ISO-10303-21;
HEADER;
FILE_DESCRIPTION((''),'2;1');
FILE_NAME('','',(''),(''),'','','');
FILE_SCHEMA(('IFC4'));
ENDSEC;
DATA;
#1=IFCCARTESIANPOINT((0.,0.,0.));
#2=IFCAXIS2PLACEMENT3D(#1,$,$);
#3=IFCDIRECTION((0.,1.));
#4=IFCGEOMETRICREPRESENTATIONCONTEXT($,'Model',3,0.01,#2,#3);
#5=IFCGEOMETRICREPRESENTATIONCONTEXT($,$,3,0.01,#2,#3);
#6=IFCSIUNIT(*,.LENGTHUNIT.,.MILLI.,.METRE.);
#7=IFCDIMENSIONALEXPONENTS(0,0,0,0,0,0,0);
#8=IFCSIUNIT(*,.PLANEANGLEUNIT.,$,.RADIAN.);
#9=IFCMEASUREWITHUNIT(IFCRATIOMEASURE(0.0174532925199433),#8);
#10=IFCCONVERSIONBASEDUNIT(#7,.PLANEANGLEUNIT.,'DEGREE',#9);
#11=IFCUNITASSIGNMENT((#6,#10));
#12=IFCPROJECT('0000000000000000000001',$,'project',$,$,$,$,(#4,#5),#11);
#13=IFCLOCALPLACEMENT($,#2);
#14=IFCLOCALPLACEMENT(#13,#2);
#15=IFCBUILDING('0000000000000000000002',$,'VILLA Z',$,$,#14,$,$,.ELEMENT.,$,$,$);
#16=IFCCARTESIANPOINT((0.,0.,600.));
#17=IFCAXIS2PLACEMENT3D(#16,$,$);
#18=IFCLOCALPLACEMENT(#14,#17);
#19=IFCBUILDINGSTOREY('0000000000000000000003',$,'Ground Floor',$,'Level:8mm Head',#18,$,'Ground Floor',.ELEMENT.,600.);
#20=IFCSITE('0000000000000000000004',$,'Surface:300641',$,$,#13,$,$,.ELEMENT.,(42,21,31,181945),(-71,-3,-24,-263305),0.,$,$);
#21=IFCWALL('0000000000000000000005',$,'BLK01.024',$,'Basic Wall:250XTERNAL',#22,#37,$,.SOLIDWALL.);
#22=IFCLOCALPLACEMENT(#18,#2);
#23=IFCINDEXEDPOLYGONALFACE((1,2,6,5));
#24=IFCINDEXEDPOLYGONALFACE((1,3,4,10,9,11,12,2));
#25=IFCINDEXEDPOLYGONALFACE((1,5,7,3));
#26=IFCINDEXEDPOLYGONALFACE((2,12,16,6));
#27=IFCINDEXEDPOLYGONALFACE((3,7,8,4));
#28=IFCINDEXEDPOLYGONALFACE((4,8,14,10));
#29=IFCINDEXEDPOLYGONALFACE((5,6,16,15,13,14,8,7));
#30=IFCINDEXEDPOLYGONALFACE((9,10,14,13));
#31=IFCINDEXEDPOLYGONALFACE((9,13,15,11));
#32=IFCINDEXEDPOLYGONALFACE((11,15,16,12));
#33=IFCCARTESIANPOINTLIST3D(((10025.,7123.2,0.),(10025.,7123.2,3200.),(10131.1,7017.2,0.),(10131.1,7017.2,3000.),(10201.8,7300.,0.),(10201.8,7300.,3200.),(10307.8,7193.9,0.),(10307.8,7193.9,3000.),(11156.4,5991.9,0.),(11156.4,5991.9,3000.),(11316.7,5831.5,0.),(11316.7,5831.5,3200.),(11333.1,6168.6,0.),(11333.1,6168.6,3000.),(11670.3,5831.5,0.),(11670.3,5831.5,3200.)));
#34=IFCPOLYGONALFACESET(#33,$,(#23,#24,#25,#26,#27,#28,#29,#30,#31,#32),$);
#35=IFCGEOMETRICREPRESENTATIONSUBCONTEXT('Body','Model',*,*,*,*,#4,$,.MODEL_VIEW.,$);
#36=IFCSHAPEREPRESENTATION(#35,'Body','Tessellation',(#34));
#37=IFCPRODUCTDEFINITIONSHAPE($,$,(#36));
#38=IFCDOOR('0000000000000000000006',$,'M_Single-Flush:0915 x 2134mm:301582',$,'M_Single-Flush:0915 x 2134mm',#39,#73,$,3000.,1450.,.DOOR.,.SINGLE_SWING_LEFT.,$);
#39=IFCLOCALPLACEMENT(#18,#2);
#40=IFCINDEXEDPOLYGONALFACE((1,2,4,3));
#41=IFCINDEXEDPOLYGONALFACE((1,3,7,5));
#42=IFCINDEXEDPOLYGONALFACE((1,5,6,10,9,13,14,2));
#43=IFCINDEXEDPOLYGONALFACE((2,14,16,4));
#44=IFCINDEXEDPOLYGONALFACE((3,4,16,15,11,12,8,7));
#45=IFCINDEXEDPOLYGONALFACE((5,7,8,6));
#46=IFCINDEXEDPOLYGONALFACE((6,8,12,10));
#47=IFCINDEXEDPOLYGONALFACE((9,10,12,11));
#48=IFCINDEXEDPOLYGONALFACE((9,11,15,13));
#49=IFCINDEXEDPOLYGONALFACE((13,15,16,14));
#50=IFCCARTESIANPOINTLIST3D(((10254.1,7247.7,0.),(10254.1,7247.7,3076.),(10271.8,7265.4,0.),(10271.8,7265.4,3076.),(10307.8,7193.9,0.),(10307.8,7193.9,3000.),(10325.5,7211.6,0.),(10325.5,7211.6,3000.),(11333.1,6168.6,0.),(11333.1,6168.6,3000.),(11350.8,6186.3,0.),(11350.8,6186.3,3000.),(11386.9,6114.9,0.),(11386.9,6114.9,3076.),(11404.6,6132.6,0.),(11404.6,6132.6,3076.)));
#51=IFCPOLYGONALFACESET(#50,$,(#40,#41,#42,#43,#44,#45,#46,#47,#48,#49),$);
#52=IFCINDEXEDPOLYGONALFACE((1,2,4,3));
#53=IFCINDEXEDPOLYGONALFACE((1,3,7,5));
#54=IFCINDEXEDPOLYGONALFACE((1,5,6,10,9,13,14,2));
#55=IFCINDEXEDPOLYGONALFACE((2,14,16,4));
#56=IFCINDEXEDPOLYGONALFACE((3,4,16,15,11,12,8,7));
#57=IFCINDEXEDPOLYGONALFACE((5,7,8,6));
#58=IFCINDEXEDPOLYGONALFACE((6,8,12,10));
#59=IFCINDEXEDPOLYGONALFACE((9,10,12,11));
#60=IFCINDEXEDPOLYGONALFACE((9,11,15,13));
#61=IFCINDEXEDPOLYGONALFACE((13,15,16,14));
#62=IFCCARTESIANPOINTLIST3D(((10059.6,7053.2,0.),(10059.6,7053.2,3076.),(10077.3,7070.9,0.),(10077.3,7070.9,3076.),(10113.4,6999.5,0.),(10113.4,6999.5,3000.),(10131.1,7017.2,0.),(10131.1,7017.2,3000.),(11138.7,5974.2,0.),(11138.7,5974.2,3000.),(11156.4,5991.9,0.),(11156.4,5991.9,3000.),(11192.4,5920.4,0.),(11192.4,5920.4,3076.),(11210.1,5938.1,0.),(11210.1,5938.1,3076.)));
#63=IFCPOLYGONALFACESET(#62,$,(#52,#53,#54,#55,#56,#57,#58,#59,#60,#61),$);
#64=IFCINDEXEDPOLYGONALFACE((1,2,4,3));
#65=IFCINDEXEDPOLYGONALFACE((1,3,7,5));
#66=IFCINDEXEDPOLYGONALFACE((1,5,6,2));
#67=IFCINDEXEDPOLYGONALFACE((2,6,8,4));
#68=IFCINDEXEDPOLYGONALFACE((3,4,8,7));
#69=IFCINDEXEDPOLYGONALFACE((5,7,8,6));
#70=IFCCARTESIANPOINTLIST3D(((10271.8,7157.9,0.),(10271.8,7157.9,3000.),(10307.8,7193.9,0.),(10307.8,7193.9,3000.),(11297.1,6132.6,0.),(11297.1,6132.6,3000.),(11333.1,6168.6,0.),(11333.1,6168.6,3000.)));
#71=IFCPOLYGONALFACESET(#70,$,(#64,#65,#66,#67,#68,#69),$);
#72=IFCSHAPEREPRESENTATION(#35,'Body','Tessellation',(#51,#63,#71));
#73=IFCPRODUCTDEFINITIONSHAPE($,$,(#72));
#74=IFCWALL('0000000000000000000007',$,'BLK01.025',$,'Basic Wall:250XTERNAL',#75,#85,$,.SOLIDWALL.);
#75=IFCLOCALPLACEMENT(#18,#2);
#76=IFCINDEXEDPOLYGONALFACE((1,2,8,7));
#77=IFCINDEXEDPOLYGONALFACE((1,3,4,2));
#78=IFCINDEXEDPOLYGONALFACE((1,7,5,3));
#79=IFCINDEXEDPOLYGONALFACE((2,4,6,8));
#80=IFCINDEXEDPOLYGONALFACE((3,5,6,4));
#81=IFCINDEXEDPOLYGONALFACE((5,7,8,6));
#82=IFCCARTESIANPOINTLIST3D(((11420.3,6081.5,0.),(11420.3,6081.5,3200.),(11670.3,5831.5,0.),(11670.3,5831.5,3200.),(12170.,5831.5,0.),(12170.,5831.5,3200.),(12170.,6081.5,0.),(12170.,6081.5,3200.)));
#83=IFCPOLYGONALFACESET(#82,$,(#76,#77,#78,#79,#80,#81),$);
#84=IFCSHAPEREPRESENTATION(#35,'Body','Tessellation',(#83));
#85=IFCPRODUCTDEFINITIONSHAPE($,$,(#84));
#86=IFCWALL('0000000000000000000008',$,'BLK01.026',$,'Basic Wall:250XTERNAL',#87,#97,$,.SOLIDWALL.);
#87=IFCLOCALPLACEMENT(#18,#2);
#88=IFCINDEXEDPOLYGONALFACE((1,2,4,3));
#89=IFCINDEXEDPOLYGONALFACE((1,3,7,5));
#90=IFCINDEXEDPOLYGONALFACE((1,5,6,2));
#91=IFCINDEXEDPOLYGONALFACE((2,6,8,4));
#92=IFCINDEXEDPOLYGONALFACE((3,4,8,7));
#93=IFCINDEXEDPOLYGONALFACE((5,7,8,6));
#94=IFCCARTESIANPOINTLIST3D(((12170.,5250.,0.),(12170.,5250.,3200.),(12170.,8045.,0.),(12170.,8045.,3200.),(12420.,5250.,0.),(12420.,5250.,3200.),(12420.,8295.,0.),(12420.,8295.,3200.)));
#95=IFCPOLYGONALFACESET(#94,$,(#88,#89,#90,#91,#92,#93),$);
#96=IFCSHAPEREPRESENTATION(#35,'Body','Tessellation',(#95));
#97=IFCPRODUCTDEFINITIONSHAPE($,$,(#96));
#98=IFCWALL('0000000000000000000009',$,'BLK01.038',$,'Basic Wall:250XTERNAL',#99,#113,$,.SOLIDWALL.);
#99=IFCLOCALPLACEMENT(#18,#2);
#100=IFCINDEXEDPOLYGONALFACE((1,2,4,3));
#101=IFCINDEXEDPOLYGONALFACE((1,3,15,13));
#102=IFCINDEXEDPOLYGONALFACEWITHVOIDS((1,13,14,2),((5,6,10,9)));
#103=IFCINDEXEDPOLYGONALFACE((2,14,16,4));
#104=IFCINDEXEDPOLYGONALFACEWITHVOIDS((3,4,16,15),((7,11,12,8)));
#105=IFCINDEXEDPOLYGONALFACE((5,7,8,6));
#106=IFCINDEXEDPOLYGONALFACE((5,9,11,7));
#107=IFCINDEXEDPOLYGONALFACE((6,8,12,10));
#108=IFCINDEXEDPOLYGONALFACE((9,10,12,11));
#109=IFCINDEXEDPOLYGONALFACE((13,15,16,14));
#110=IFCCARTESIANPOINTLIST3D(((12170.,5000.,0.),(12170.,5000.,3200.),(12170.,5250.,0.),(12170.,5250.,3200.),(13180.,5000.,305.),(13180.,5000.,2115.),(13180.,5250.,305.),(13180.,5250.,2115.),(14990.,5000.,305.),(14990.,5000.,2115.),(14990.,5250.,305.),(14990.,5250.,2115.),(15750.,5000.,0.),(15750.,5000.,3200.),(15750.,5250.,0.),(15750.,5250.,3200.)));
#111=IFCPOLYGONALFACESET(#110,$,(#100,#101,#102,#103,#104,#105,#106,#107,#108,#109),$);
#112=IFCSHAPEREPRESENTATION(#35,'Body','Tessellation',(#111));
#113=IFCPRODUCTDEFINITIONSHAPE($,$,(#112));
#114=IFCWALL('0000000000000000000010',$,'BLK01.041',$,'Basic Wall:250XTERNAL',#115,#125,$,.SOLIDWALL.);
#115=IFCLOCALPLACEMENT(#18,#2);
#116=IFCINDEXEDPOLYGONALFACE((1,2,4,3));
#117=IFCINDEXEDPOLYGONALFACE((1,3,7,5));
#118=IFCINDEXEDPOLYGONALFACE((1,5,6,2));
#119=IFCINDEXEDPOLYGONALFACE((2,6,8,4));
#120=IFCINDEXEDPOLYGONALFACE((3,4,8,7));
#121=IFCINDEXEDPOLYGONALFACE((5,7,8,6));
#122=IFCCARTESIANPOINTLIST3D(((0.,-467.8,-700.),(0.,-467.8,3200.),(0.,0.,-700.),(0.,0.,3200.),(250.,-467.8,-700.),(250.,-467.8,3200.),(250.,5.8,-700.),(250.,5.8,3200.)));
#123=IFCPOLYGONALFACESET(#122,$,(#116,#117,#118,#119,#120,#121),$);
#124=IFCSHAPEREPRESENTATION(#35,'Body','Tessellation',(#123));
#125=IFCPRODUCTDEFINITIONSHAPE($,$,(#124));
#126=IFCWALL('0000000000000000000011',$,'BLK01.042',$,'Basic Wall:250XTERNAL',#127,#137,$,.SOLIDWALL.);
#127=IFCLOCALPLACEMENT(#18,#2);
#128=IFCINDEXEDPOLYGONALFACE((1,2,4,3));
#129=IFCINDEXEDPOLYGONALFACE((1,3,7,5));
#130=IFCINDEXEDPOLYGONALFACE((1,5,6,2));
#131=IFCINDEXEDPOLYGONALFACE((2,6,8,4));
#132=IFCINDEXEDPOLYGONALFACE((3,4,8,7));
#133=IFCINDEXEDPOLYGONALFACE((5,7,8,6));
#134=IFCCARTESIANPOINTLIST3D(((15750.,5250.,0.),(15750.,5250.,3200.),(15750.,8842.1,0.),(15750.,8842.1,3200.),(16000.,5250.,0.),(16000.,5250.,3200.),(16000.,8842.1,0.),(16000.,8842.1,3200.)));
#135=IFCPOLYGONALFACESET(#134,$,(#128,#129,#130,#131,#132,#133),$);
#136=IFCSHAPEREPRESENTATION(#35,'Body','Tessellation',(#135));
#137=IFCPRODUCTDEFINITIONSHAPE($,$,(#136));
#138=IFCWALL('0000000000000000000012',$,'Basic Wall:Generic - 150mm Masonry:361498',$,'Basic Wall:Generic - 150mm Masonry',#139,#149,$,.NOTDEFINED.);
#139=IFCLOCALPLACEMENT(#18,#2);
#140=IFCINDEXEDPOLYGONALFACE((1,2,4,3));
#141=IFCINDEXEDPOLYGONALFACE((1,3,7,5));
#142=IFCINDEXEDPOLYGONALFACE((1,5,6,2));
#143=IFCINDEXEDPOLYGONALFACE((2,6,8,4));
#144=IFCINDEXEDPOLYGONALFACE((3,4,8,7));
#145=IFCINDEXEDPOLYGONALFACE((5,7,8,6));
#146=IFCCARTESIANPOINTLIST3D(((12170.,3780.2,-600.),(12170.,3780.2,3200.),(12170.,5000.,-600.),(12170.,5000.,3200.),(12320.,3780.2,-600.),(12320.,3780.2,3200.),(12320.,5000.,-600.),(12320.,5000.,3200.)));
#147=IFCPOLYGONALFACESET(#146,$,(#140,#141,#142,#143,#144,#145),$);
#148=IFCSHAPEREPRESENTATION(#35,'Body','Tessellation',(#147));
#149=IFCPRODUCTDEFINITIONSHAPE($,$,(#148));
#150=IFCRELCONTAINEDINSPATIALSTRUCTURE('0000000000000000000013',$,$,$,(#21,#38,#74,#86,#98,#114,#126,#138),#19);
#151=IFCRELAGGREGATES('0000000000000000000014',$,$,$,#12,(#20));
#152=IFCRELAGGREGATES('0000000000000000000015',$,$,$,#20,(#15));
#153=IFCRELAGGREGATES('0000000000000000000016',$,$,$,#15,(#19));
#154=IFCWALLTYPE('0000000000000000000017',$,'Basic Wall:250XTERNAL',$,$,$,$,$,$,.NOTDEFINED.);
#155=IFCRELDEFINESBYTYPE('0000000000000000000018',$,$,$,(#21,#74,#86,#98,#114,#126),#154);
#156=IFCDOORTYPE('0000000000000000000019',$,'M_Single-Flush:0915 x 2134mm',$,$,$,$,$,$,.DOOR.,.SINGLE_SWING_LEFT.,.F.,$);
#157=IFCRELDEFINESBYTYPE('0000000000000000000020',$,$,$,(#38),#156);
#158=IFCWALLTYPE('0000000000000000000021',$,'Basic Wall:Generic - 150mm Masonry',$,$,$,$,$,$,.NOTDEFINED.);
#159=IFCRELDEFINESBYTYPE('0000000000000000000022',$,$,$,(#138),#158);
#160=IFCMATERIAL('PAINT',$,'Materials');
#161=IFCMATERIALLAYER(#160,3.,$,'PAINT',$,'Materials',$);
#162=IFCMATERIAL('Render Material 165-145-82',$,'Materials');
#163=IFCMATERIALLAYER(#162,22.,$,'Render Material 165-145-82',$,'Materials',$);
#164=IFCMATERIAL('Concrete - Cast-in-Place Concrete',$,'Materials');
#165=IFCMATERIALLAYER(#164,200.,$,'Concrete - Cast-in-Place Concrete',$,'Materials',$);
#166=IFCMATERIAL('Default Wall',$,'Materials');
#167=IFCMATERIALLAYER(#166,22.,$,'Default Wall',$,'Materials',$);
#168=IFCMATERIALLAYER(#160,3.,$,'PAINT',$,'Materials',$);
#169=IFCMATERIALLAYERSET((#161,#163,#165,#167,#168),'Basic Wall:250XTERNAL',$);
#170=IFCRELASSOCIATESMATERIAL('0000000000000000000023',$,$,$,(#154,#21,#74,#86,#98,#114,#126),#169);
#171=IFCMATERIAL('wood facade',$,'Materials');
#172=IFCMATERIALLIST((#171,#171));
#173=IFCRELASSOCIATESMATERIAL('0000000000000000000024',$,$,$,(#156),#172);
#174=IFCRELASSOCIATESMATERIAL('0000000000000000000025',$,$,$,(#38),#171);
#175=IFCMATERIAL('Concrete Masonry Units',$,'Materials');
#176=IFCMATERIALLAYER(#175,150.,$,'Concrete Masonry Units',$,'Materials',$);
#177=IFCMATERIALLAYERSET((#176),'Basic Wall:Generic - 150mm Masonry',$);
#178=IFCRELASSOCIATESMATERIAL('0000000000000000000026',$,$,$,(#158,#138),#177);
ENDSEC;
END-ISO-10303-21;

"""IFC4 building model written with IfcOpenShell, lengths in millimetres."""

from ifc_helpers import new_model, entity, si_unit, converted_unit, direction, frame, frame_2d, origin, place, context, subcontext, project, spatial, polyline, rectangle, outline, extrude, clip, halfspace, source, transform, mapped, material, material_list, layer, layer_set, layer_usage, type_object, type_shapes, element, fill, save


model = new_model("IFC4")

# Units and contexts
model_context = context("Model", 3, precision=0.01, world=origin(), true_north=direction((0.0, 1.0)))
context_of_model = context(None, 3, precision=0.01, world=origin(), true_north=direction((0.0, 1.0)))
body_context = subcontext(model_context, "Body", "Model", "MODEL_VIEW")
ifc_project = project(units=[si_unit("LENGTHUNIT", "METRE", prefix="MILLI"), converted_unit("PLANEANGLEUNIT", "DEGREE", entity("IfcRatioMeasure", 0.0174532925199433), si_unit("PLANEANGLEUNIT", "RADIAN"), dimensions=[0, 0, 0, 0, 0, 0, 0])], contexts=[model_context, context_of_model])

# Site, building, storey
site_placement = place(None, origin())
site = spatial("IfcSite", under=ifc_project, at=site_placement, Name="Surface:300641", CompositionType="ELEMENT", RefLatitude=(42, 21, 31, 181945), RefLongitude=(-71, -3, -24, -263305), RefElevation=0.0)
building_placement = place(site_placement, origin())
building = spatial("IfcBuilding", under=site, at=building_placement, Name="VILLA Z", CompositionType="ELEMENT")
storey_placement = place(building_placement, frame((0.0, 0.0, 600.0)))
storey = spatial("IfcBuildingStorey", under=building, at=storey_placement, Name="Ground Floor", ObjectType="Level:8mm Head", LongName="Ground Floor", CompositionType="ELEMENT", Elevation=600.0)

# Shared definitions
ifc_material_1 = material(Name="Concrete - Cast-in-Place Concrete", Category="Materials")

# Shared definitions
ifc_material_2 = material(Name="PAINT", Category="Materials")
ifc_layer_1 = layer(ifc_material_2, 3.0, Name="PAINT", Category="Materials")
ifc_material_3 = material(Name="Render Material 165-145-82", Category="Materials")
ifc_layer_2 = layer(ifc_material_3, 22.0, Name="Render Material 165-145-82", Category="Materials")
ifc_layer_3 = layer(ifc_material_1, 200.0, Name="Concrete - Cast-in-Place Concrete", Category="Materials")
ifc_material_4 = material(Name="Default Wall", Category="Materials")
ifc_layer_4 = layer(ifc_material_4, 22.0, Name="Default Wall", Category="Materials")
ifc_layer_5 = layer(ifc_material_2, 3.0, Name="PAINT", Category="Materials")
ifc_layer_set_1 = layer_set([ifc_layer_1, ifc_layer_2, ifc_layer_3, ifc_layer_4, ifc_layer_5], Name="Basic Wall:250XTERNAL")
wall_type_1 = type_object("IfcWallType", Name="Basic Wall:250XTERNAL", PredefinedType="NOTDEFINED", material=ifc_layer_set_1)

# Wall, opening, door
ifc_layer_usage_1 = layer_usage(ifc_layer_set_1, "AXIS2", "NEGATIVE", 125.0)
wall_1_placement = place(storey_placement, frame((10113.4, 7211.6, 0.0), z_axis=(0.0, 0.0, 1.0), x_axis=(0.707107, -0.707107, 0.0)))
wall_1 = element("IfcWall", 1, at=wall_1_placement, inside=storey, type_object=wall_type_1, material=ifc_layer_usage_1, Name="BLK01.024", ObjectType="Basic Wall:250XTERNAL", PredefinedType="SOLIDWALL", context=body_context, shape_type="Clipping", body=[
    clip(extrude(outline(polyline([(0.0, -125.0), (1826.8, -125.0), (2076.8, 125.0), (1723.2, 125.0), (0.0, 125.0), (0.0, -125.0)])), origin(), (0.0, 0.0, 1.0), 3200.0), halfspace(origin(), True)),
])
opening_1_placement = place(wall_1_placement, frame((150.0, -125.0, 0.0)))
opening_1 = element("IfcOpeningElement", 2, at=opening_1_placement, cuts=wall_1, ObjectType="Opening", PredefinedType="OPENING", context=body_context, shape_type="SweptSolid", body=[
    extrude(rectangle(XDim=1450.0, YDim=3000.0, at=frame_2d((1500.0, 725.0), x_axis=(0.0, -1.0))), frame((0.0, 0.0, 0.0), z_axis=(0.0, 1.0, 0.0), x_axis=(0.0, 0.0, 1.0)), (0.0, 0.0, 1.0), 250.0),
])
ifc_material_5 = material(Name="wood facade", Category="Materials")
ifc_material_list = material_list([ifc_material_5, ifc_material_5])
door_type = type_object("IfcDoorType", Name="M_Single-Flush:0915 x 2134mm", OperationType="SINGLE_SWING_LEFT", ParameterTakesPrecedence=False, PredefinedType="DOOR", material=ifc_material_list)
shared_shape_1 = source(origin(), body_context, "Body", "SweptSolid", [
    extrude(outline(polyline([(-801.0, -1557.0), (801.0, -1557.0), (801.0, 1519.0), (725.0, 1519.0), (725.0, -1481.0), (-725.0, -1481.0), (-725.0, 1519.0), (-801.0, 1519.0), (-801.0, -1557.0)])), frame((725.0, 275.0, 1519.0), z_axis=(0.0, -1.0, 0.0), x_axis=(-1.0, 0.0, 0.0)), (0.0, 0.0, 1.0), 25.0),
    extrude(outline(polyline([(-1557.0, -801.0), (1519.0, -801.0), (1519.0, -725.0), (-1481.0, -725.0), (-1481.0, 725.0), (1519.0, 725.0), (1519.0, 801.0), (-1557.0, 801.0), (-1557.0, -801.0)])), frame((725.0, 0.0, 1519.0), z_axis=(0.0, -1.0, 0.0), x_axis=(0.0, 0.0, -1.0)), (0.0, 0.0, 1.0), 25.0),
    extrude(rectangle(XDim=1450.0, YDim=51.0, at=frame_2d((0.0, 0.0), x_axis=(1.0, 0.0))), frame((725.0, 224.5, 0.0)), (0.0, 0.0, 1.0), 3000.0),
])
type_shapes(door_type, [shared_shape_1])
door_placement = place(opening_1_placement, origin())
door = element("IfcDoor", 3, at=door_placement, inside=storey, type_object=door_type, material=ifc_material_5, Name="M_Single-Flush:0915 x 2134mm:301582", ObjectType="M_Single-Flush:0915 x 2134mm", OperationType="SINGLE_SWING_LEFT", OverallHeight=3000.0, OverallWidth=1450.0, PredefinedType="DOOR", context=body_context, shape_type="MappedRepresentation", body=[
    mapped(shared_shape_1, transform((0.0, 0.0, 0.0), scale=1.0)),
])
fill(opening_1, door)

# Walls
ifc_layer_usage_2 = layer_usage(ifc_layer_set_1, "AXIS2", "NEGATIVE", 125.0)
wall_2_placement = place(storey_placement, frame((11420.3, 5956.5, 0.0)))
element("IfcWall", 4, at=wall_2_placement, inside=storey, type_object=wall_type_1, material=ifc_layer_usage_2, Name="BLK01.025", ObjectType="Basic Wall:250XTERNAL", PredefinedType="SOLIDWALL", context=body_context, shape_type="Clipping", body=[
    clip(extrude(outline(polyline([(749.7, -125.0), (749.7, 125.0), (0.0, 125.0), (250.0, -125.0), (749.7, -125.0)])), origin(), (0.0, 0.0, 1.0), 3200.0), halfspace(origin(), True)),
])
ifc_layer_usage_3 = layer_usage(ifc_layer_set_1, "AXIS2", "NEGATIVE", 125.0)
wall_3_placement = place(storey_placement, frame((12295.0, 5250.0, 0.0), z_axis=(0.0, 0.0, 1.0), x_axis=(0.0, 1.0, 0.0)))
element("IfcWall", 5, at=wall_3_placement, inside=storey, type_object=wall_type_1, material=ifc_layer_usage_3, Name="BLK01.026", ObjectType="Basic Wall:250XTERNAL", PredefinedType="SOLIDWALL", context=body_context, shape_type="Clipping", body=[
    clip(extrude(outline(polyline([(3045.0, -125.0), (2795.0, 125.0), (831.5, 125.0), (581.5, 125.0), (0.0, 125.0), (0.0, -125.0), (2691.4, -125.0), (3045.0, -125.0)])), origin(), (0.0, 0.0, 1.0), 3200.0), halfspace(origin(), True)),
])

# Wall, opening
ifc_layer_usage_4 = layer_usage(ifc_layer_set_1, "AXIS2", "NEGATIVE", 125.0)
wall_4_placement = place(storey_placement, frame((12170.0, 5125.0, 0.0)))
wall_4 = element("IfcWall", 6, at=wall_4_placement, inside=storey, type_object=wall_type_1, material=ifc_layer_usage_4, Name="BLK01.038", ObjectType="Basic Wall:250XTERNAL", PredefinedType="SOLIDWALL", context=body_context, shape_type="Clipping", body=[
    clip(extrude(rectangle(XDim=3580.0, YDim=250.0, at=frame_2d((1790.0, 0.0), x_axis=(-1.0, 0.0))), origin(), (0.0, 0.0, 1.0), 3200.0), halfspace(origin(), True)),
])
opening_2_placement = place(wall_4_placement, frame((1010.0, -125.0, 305.0)))
element("IfcOpeningElement", 7, at=opening_2_placement, cuts=wall_4, ObjectType="Opening", PredefinedType="OPENING", context=body_context, shape_type="SweptSolid", body=[
    extrude(rectangle(XDim=1810.0, YDim=1810.0, at=frame_2d((905.0, 905.0), x_axis=(-1.0, 0.0))), frame((0.0, 0.0, 0.0), z_axis=(0.0, 1.0, 0.0), x_axis=(0.0, 0.0, 1.0)), (0.0, 0.0, 1.0), 250.0),
])

# Walls
ifc_layer_usage_5 = layer_usage(ifc_layer_set_1, "AXIS2", "NEGATIVE", 125.0)
wall_5_placement = place(storey_placement, frame((125.0, 5.8, -700.0), z_axis=(0.0, 0.0, 1.0), x_axis=(0.0, -1.0, 0.0)))
element("IfcWall", 8, at=wall_5_placement, inside=storey, type_object=wall_type_1, material=ifc_layer_usage_5, Name="BLK01.041", ObjectType="Basic Wall:250XTERNAL", PredefinedType="SOLIDWALL", context=body_context, shape_type="SweptSolid", body=[
    extrude(outline(polyline([(473.5, -125.0), (473.5, 125.0), (0.0, 125.0), (5.8, -125.0), (473.5, -125.0)])), origin(), (0.0, 0.0, 1.0), 3900.0),
])
ifc_layer_usage_6 = layer_usage(ifc_layer_set_1, "AXIS2", "NEGATIVE", 125.0)
wall_6_placement = place(storey_placement, frame((15875.0, 5250.0, 0.0), z_axis=(0.0, 0.0, 1.0), x_axis=(0.0, 1.0, 0.0)))
element("IfcWall", 9, at=wall_6_placement, inside=storey, type_object=wall_type_1, material=ifc_layer_usage_6, Name="BLK01.042", ObjectType="Basic Wall:250XTERNAL", PredefinedType="SOLIDWALL", context=body_context, shape_type="Clipping", body=[
    clip(extrude(rectangle(XDim=3592.1, YDim=250.0, at=frame_2d((1796.1, 0.0), x_axis=(-1.0, 0.0))), origin(), (0.0, 0.0, 1.0), 3200.0), halfspace(origin(), True)),
])
ifc_material_6 = material(Name="Concrete Masonry Units", Category="Materials")
ifc_layer_6 = layer(ifc_material_6, 150.0, Name="Concrete Masonry Units", Category="Materials")
ifc_layer_set_2 = layer_set([ifc_layer_6], Name="Basic Wall:Generic - 150mm Masonry")
ifc_layer_usage_7 = layer_usage(ifc_layer_set_2, "AXIS2", "NEGATIVE", 75.0)
wall_type_2 = type_object("IfcWallType", Name="Basic Wall:Generic - 150mm Masonry", PredefinedType="NOTDEFINED", material=ifc_layer_set_2)
wall_7_placement = place(storey_placement, frame((12245.0, 5000.0, -600.0), z_axis=(0.0, 0.0, 1.0), x_axis=(0.0, -1.0, 0.0)))
element("IfcWall", 10, at=wall_7_placement, inside=storey, type_object=wall_type_2, material=ifc_layer_usage_7, Name="Basic Wall:Generic - 150mm Masonry:361498", ObjectType="Basic Wall:Generic - 150mm Masonry", PredefinedType="NOTDEFINED", context=body_context, shape_type="Clipping", body=[
    clip(extrude(rectangle(XDim=1219.8, YDim=150.0, at=frame_2d((609.9, 0.0), x_axis=(-1.0, 0.0))), origin(), (0.0, 0.0, 1.0), 3800.0), halfspace(frame((0.0, 0.0, -600.0)), True)),
])

save(model, "model.ifc")
